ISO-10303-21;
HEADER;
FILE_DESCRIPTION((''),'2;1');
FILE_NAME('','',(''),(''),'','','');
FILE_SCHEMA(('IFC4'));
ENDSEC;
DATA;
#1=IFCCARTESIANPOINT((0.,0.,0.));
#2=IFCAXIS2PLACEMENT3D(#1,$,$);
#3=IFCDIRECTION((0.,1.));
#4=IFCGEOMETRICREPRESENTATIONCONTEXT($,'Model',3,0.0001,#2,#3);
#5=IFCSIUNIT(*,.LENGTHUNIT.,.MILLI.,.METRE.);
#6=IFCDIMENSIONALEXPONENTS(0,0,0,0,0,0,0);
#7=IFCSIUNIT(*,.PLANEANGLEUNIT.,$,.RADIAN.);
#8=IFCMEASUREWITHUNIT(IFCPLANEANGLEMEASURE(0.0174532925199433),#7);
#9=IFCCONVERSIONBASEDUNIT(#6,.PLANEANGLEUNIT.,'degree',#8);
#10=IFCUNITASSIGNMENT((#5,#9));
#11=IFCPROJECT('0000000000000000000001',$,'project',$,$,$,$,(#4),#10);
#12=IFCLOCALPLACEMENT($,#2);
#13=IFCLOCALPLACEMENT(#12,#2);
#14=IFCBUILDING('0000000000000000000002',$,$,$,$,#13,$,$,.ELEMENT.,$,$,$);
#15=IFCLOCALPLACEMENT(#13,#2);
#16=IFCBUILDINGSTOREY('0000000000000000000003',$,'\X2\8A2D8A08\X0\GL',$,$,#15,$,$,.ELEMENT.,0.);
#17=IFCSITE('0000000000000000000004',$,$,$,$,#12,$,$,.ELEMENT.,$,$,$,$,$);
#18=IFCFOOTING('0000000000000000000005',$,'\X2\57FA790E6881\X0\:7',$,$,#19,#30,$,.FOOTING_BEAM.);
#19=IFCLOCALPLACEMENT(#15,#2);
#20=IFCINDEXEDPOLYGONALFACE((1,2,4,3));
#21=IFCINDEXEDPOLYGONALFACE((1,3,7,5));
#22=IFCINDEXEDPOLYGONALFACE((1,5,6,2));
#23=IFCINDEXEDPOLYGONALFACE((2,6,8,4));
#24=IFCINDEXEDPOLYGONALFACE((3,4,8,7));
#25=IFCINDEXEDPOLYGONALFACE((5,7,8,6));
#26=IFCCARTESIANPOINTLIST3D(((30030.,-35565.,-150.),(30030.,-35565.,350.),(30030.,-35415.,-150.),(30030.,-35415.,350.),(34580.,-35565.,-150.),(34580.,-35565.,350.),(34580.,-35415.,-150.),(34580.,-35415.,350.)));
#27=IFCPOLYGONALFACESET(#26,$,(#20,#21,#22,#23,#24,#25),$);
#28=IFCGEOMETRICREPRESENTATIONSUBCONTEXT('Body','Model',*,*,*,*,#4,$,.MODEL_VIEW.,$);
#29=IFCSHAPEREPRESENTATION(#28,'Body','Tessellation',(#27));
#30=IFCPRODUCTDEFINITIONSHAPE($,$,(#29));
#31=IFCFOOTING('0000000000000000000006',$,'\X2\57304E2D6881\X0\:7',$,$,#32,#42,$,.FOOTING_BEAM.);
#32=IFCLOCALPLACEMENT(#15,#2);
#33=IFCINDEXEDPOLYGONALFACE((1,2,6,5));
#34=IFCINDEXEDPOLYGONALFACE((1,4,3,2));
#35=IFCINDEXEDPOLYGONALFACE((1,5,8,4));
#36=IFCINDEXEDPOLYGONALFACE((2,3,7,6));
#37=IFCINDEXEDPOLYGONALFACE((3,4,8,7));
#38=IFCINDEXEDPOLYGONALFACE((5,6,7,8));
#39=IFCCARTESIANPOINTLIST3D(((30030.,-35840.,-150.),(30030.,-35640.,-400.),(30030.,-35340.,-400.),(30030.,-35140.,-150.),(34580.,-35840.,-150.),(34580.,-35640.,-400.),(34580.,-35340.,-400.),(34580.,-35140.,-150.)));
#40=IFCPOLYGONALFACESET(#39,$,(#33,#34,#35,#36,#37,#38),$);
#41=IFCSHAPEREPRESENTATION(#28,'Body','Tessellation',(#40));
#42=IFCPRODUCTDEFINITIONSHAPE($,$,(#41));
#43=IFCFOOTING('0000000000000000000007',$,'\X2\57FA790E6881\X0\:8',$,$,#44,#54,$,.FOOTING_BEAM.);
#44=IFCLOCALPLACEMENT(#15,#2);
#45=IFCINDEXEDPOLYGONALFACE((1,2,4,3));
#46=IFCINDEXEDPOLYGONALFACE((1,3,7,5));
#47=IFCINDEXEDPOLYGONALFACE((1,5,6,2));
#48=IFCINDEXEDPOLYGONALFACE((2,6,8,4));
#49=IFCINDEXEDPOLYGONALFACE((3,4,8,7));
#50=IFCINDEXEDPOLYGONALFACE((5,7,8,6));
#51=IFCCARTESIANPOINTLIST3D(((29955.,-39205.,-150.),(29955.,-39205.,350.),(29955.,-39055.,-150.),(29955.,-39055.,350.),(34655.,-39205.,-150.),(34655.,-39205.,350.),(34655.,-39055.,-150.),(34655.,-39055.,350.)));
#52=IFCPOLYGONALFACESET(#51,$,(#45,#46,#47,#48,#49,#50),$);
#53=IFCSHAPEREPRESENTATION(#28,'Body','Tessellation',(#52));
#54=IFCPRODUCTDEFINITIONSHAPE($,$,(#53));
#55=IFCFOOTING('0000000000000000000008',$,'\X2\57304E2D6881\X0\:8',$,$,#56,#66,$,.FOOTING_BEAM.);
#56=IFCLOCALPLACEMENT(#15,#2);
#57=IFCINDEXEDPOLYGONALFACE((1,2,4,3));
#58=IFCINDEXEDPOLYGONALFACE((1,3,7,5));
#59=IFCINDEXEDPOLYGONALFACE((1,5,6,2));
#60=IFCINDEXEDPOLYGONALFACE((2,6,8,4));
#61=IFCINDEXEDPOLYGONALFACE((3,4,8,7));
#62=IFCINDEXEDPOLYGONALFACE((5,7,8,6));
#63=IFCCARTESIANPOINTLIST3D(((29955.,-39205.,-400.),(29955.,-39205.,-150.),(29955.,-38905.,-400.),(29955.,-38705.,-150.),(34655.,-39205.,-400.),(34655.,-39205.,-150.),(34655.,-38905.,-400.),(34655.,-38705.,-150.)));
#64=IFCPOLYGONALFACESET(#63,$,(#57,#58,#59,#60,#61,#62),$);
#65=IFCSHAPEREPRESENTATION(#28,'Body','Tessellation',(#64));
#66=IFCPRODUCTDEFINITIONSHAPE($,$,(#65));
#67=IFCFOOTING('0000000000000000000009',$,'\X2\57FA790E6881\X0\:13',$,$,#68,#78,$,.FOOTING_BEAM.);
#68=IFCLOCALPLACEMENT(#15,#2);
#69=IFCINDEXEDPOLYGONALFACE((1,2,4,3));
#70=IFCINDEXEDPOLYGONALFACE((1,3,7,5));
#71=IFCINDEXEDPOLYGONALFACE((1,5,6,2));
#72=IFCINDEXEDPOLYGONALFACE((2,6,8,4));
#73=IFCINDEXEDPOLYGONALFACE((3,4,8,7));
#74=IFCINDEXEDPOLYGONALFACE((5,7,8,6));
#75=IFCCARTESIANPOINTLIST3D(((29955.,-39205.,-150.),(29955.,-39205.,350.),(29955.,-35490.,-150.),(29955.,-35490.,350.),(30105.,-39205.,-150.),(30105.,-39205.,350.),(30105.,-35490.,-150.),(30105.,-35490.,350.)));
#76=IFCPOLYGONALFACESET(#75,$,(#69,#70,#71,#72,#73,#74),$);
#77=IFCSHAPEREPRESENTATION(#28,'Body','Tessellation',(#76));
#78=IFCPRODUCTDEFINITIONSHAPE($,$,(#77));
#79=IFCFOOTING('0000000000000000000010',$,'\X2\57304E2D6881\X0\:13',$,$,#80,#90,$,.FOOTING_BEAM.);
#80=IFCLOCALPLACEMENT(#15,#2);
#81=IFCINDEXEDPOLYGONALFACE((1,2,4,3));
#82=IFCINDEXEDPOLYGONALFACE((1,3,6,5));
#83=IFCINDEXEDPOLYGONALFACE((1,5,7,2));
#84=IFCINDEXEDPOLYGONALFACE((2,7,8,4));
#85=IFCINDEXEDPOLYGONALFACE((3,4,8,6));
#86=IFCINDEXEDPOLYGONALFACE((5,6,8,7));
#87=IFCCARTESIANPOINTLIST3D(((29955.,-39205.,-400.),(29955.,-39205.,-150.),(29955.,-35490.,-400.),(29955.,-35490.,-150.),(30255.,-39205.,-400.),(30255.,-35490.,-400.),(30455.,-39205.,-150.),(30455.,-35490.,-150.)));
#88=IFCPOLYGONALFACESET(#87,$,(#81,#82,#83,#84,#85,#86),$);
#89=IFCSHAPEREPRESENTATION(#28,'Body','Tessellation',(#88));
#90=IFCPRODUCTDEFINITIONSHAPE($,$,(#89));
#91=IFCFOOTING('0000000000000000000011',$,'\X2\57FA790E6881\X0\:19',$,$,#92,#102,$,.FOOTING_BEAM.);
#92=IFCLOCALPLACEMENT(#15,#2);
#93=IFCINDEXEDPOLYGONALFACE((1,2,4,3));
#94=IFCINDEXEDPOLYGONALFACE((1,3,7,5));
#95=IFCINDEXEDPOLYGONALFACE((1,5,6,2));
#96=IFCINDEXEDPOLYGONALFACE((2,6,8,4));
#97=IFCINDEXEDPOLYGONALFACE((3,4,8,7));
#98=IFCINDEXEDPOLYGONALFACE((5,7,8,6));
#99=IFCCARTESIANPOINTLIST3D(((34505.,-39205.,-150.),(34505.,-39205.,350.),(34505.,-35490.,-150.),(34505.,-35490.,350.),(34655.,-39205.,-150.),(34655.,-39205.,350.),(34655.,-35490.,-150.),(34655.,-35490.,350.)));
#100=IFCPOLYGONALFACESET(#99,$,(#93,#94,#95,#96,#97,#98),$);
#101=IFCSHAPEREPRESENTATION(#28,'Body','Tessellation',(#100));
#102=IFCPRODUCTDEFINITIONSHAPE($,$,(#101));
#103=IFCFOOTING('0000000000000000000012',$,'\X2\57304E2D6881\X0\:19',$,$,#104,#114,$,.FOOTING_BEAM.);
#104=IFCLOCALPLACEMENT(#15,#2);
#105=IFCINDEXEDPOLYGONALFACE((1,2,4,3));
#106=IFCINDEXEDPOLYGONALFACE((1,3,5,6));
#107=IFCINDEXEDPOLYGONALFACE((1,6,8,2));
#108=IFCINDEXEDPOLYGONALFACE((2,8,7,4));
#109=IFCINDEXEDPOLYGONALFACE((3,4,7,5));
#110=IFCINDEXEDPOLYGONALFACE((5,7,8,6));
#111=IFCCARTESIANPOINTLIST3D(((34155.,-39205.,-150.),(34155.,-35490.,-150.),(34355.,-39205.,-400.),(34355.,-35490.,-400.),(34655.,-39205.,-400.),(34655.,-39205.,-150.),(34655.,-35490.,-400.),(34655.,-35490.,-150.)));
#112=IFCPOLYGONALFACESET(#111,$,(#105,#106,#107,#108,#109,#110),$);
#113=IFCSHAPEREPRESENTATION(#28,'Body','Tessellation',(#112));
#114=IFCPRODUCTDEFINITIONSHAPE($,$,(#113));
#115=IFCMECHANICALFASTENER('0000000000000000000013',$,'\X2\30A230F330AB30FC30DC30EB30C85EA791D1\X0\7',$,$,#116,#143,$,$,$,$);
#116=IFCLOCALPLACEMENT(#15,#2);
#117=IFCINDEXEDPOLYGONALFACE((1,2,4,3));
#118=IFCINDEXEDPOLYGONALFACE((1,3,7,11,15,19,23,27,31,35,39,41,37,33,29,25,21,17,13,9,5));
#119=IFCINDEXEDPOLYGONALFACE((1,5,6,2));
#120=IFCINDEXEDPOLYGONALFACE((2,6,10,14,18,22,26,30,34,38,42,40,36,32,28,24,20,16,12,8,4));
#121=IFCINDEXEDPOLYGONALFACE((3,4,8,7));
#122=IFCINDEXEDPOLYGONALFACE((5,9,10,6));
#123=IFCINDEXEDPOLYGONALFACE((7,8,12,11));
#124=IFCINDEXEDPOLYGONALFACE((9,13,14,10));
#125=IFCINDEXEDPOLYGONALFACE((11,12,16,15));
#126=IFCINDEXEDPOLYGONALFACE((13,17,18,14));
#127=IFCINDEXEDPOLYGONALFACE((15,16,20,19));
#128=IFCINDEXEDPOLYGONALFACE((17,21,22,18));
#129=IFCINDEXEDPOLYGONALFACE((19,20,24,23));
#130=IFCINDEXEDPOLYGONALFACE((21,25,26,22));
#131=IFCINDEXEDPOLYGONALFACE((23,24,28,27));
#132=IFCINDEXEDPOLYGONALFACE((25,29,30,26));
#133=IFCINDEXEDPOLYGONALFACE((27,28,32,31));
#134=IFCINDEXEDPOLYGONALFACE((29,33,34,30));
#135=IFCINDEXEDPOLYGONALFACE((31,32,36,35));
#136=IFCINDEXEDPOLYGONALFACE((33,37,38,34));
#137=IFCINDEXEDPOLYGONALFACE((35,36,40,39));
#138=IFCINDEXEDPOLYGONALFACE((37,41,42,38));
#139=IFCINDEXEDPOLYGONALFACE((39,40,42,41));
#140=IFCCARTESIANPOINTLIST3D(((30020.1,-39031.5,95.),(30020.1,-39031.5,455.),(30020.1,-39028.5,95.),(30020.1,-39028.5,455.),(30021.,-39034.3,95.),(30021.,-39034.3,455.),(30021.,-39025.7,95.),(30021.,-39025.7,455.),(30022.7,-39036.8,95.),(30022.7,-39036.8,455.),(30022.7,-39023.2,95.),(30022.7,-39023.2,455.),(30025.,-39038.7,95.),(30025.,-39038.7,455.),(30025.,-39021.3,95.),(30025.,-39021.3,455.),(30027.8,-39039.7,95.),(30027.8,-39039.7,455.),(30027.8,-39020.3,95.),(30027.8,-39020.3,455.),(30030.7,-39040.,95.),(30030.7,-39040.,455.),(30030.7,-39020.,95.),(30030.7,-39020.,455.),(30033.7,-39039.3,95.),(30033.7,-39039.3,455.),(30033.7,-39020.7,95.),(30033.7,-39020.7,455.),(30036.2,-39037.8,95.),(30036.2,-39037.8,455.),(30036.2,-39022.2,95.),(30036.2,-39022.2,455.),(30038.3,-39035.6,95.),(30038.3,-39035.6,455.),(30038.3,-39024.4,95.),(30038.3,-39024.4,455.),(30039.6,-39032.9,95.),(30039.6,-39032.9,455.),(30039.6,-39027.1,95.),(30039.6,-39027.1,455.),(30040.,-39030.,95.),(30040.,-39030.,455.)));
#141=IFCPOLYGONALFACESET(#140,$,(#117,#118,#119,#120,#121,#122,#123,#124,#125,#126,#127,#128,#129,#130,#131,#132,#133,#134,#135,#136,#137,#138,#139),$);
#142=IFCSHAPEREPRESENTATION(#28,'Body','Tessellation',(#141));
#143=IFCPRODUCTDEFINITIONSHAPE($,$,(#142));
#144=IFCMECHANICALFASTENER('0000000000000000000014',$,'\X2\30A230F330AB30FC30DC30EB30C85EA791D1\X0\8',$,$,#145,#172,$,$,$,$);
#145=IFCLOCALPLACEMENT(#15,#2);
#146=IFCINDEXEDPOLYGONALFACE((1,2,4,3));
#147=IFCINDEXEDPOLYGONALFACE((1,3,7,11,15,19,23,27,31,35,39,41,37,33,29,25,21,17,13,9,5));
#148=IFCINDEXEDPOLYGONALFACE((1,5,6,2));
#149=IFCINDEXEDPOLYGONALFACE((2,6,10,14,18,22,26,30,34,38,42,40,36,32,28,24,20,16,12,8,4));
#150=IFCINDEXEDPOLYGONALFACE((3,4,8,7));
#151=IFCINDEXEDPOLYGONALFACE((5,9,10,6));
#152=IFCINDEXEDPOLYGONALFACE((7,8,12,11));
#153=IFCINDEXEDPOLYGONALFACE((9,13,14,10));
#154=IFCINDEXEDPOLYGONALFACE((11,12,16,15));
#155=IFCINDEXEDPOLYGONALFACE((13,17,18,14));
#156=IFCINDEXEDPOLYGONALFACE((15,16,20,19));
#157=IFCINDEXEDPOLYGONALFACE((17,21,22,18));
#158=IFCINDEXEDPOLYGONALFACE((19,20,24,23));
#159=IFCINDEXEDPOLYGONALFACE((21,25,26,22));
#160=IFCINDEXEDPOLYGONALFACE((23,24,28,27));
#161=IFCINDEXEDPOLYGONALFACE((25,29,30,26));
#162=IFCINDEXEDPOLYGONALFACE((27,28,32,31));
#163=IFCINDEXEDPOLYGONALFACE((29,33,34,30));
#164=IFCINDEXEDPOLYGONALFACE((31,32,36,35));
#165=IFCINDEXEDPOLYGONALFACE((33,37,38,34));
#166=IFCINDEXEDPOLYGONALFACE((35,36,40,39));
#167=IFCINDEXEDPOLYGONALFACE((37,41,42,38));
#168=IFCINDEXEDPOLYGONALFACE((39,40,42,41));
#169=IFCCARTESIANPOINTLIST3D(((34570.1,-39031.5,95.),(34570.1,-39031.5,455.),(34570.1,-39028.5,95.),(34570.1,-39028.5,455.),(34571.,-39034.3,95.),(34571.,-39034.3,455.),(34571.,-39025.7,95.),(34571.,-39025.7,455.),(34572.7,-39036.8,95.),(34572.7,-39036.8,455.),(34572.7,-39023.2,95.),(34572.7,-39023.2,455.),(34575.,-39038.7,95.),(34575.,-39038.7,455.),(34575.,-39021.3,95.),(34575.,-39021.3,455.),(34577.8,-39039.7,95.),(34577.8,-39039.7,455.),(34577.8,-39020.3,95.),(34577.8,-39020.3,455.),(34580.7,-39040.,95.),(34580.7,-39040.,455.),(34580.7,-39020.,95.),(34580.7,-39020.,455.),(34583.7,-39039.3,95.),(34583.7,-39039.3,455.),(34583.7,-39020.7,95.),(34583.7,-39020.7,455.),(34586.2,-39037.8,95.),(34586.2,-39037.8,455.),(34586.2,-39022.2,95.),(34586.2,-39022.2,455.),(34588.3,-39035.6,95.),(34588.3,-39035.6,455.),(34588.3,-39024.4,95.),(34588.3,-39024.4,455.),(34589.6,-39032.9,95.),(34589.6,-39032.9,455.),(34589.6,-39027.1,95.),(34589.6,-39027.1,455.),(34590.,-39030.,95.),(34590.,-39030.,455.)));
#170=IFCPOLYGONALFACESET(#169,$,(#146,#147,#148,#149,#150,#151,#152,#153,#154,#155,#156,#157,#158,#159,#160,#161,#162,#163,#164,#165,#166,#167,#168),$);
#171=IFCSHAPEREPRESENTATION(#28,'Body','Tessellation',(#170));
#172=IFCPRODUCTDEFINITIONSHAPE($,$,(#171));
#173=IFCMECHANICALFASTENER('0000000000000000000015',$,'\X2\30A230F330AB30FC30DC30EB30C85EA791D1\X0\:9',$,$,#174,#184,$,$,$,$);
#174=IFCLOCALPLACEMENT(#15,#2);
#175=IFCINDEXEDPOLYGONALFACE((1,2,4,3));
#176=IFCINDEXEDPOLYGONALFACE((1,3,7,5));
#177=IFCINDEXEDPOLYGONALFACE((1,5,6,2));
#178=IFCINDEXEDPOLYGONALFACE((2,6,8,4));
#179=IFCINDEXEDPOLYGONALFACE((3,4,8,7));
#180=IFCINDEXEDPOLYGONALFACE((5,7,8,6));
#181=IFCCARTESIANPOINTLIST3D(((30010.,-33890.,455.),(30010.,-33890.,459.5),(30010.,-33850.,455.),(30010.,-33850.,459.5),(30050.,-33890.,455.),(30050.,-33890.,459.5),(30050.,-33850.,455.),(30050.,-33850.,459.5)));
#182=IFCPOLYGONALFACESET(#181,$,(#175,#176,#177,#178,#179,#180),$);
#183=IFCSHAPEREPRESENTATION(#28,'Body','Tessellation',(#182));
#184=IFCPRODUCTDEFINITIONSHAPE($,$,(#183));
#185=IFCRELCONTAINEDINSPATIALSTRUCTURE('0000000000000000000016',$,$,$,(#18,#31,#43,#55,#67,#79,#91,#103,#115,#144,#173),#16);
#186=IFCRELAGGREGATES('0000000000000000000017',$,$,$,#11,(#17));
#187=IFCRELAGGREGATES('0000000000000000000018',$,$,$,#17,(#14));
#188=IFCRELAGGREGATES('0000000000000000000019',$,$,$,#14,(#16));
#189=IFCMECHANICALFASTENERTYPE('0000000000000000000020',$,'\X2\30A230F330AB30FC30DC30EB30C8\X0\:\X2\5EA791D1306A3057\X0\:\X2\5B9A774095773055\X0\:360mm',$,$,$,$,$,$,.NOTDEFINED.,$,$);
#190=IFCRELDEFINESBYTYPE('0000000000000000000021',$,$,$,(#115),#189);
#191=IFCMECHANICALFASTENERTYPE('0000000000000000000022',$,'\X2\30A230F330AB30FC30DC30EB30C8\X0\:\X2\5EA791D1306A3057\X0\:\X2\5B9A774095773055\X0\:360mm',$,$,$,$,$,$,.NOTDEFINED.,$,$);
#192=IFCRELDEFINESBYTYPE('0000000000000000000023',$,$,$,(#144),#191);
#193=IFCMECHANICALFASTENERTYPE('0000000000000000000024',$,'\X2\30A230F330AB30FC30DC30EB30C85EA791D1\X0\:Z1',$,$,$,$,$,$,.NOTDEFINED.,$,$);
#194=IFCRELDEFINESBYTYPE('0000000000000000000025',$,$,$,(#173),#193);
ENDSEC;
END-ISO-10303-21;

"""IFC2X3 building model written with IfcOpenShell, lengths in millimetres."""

from ifc_helpers import new_model, entity, si_unit, converted_unit, direction, frame, origin, origin_with_axes, origin_2d, place, context, subcontext, project, spatial, polyline, rectangle, circle, outline, extrude, type_object, element, save


model = new_model("IFC2X3")

# Units and contexts
model_context = context("Model", 3, precision=0.0001, world=origin(), true_north=direction((0.0, 1.0)))
body_context = subcontext(model_context, "Body", "Model", "MODEL_VIEW")
ifc_project = project(units=[si_unit("LENGTHUNIT", "METRE", prefix="MILLI"), converted_unit("PLANEANGLEUNIT", "degree", entity("IfcPlaneAngleMeasure", 0.0174532925199433), si_unit("PLANEANGLEUNIT", "RADIAN"), dimensions=[0, 0, 0, 0, 0, 0, 0])], contexts=[model_context])

# Site, building, storey
site_placement = place(None, origin())
site = spatial("IfcSite", under=ifc_project, at=site_placement, CompositionType="ELEMENT")
building_placement = place(site_placement, origin())
building = spatial("IfcBuilding", under=site, at=building_placement, CompositionType="ELEMENT")
storey_placement = place(building_placement, origin())
storey = spatial("IfcBuildingStorey", under=building, at=storey_placement, Name="設計GL", CompositionType="ELEMENT", Elevation=0.0)

# Footings
footing_1_placement = place(storey_placement, frame((30030.0, -35490.0, 100.0), z_axis=(1.0, 0.0, 0.0), x_axis=(0.0, 1.0, 0.0)))
element("IfcFooting", 1, at=footing_1_placement, inside=storey, Name="基礎梁:7", PredefinedType="FOOTING_BEAM", context=body_context, shape_type="SolidModel", body=[
    extrude(rectangle(XDim=150.0, YDim=500.0, at=origin_2d()), origin_with_axes(), (0.0, 0.0, 1.0), 4550.0),
])
footing_2_placement = place(storey_placement, frame((30030.0, -35490.0, -400.0), z_axis=(1.0, 0.0, 0.0), x_axis=(0.0, 1.0, 0.0)))
element("IfcFooting", 2, at=footing_2_placement, inside=storey, Name="地中梁:7", PredefinedType="FOOTING_BEAM", context=body_context, shape_type="SweptSolid", body=[
    extrude(outline(polyline([(-150.0, 0.0, 0.0), (150.0, 0.0, 0.0), (350.0, 250.0, 0.0), (-350.0, 250.0, 0.0), (-150.0, 0.0, 0.0)])), origin_with_axes(), (0.0, 0.0, 1.0), 4550.0),
])
footing_3_placement = place(storey_placement, frame((29955.0, -39130.0, 100.0), z_axis=(1.0, 0.0, 0.0), x_axis=(0.0, 1.0, 0.0)))
element("IfcFooting", 3, at=footing_3_placement, inside=storey, Name="基礎梁:8", PredefinedType="FOOTING_BEAM", context=body_context, shape_type="SolidModel", body=[
    extrude(rectangle(XDim=150.0, YDim=500.0, at=origin_2d()), origin_with_axes(), (0.0, 0.0, 1.0), 4700.0),
])
footing_4_placement = place(storey_placement, frame((29955.0, -39205.0, -400.0), z_axis=(1.0, 0.0, 0.0), x_axis=(0.0, 1.0, 0.0)))
element("IfcFooting", 4, at=footing_4_placement, inside=storey, Name="地中梁:8", PredefinedType="FOOTING_BEAM", context=body_context, shape_type="SweptSolid", body=[
    extrude(outline(polyline([(0.0, 0.0, 0.0), (300.0, 0.0, 0.0), (500.0, 250.0, 0.0), (0.0, 250.0, 0.0), (0.0, 0.0, 0.0)])), origin_with_axes(), (0.0, 0.0, 1.0), 4700.0),
])
footing_5_placement = place(storey_placement, frame((30030.0, -35490.0, 100.0), z_axis=(0.0, -1.0, 0.0), x_axis=(1.0, 0.0, 0.0)))
element("IfcFooting", 5, at=footing_5_placement, inside=storey, Name="基礎梁:13", PredefinedType="FOOTING_BEAM", context=body_context, shape_type="SolidModel", body=[
    extrude(rectangle(XDim=150.0, YDim=500.0, at=origin_2d()), origin_with_axes(), (0.0, 0.0, 1.0), 3715.0),
])
footing_6_placement = place(storey_placement, frame((29955.0, -35490.0, -400.0), z_axis=(0.0, -1.0, 0.0), x_axis=(1.0, 0.0, 0.0)))
element("IfcFooting", 6, at=footing_6_placement, inside=storey, Name="地中梁:13", PredefinedType="FOOTING_BEAM", context=body_context, shape_type="SweptSolid", body=[
    extrude(outline(polyline([(0.0, 0.0, 0.0), (300.0, 0.0, 0.0), (500.0, 250.0, 0.0), (0.0, 250.0, 0.0), (0.0, 0.0, 0.0)])), origin_with_axes(), (0.0, 0.0, 1.0), 3715.0),
])
footing_7_placement = place(storey_placement, frame((34580.0, -35490.0, 100.0), z_axis=(0.0, -1.0, 0.0), x_axis=(1.0, 0.0, 0.0)))
element("IfcFooting", 7, at=footing_7_placement, inside=storey, Name="基礎梁:19", PredefinedType="FOOTING_BEAM", context=body_context, shape_type="SolidModel", body=[
    extrude(rectangle(XDim=150.0, YDim=500.0, at=origin_2d()), origin_with_axes(), (0.0, 0.0, 1.0), 3715.0),
])
footing_8_placement = place(storey_placement, frame((34655.0, -35490.0, -400.0), z_axis=(0.0, -1.0, 0.0), x_axis=(1.0, 0.0, 0.0)))
element("IfcFooting", 8, at=footing_8_placement, inside=storey, Name="地中梁:19", PredefinedType="FOOTING_BEAM", context=body_context, shape_type="SweptSolid", body=[
    extrude(outline(polyline([(0.0, 0.0, 0.0), (-300.0, 0.0, 0.0), (-500.0, 250.0, 0.0), (0.0, 250.0, 0.0), (0.0, 0.0, 0.0)])), origin_with_axes(), (0.0, 0.0, 1.0), 3715.0),
])

# Mechanical fasteners
mechanical_fastener_type_1 = type_object("IfcMechanicalFastenerType", Name="アンカーボルト:座金なし:定着長さ:360mm")
mechanical_fastener_1_placement = place(storey_placement, frame((30030.0, -39030.0, 95.0)))
element("IfcMechanicalFastener", 9, at=mechanical_fastener_1_placement, inside=storey, type_object=mechanical_fastener_type_1, Name="アンカーボルト座金7", context=body_context, shape_type="SweptSolid", body=[
    extrude(circle(Radius=10.0, at=origin_2d()), origin_with_axes(), (0.0, 0.0, 1.0), 360.0),
])
mechanical_fastener_type_2 = type_object("IfcMechanicalFastenerType", Name="アンカーボルト:座金なし:定着長さ:360mm")
mechanical_fastener_2_placement = place(storey_placement, frame((34580.0, -39030.0, 95.0)))
element("IfcMechanicalFastener", 10, at=mechanical_fastener_2_placement, inside=storey, type_object=mechanical_fastener_type_2, Name="アンカーボルト座金8", context=body_context, shape_type="SweptSolid", body=[
    extrude(circle(Radius=10.0, at=origin_2d()), origin_with_axes(), (0.0, 0.0, 1.0), 360.0),
])
mechanical_fastener_type_3 = type_object("IfcMechanicalFastenerType", Name="アンカーボルト座金:Z1")
mechanical_fastener_3_placement = place(storey_placement, frame((30030.0, -33870.0, 455.0)))
element("IfcMechanicalFastener", 11, at=mechanical_fastener_3_placement, inside=storey, type_object=mechanical_fastener_type_3, Name="アンカーボルト座金:9", context=body_context, shape_type="SweptSolid", body=[
    extrude(rectangle(XDim=40.0, YDim=40.0, at=origin_2d()), origin_with_axes(), (0.0, 0.0, 1.0), 4.5),
])

save(model, "model.ifc")
